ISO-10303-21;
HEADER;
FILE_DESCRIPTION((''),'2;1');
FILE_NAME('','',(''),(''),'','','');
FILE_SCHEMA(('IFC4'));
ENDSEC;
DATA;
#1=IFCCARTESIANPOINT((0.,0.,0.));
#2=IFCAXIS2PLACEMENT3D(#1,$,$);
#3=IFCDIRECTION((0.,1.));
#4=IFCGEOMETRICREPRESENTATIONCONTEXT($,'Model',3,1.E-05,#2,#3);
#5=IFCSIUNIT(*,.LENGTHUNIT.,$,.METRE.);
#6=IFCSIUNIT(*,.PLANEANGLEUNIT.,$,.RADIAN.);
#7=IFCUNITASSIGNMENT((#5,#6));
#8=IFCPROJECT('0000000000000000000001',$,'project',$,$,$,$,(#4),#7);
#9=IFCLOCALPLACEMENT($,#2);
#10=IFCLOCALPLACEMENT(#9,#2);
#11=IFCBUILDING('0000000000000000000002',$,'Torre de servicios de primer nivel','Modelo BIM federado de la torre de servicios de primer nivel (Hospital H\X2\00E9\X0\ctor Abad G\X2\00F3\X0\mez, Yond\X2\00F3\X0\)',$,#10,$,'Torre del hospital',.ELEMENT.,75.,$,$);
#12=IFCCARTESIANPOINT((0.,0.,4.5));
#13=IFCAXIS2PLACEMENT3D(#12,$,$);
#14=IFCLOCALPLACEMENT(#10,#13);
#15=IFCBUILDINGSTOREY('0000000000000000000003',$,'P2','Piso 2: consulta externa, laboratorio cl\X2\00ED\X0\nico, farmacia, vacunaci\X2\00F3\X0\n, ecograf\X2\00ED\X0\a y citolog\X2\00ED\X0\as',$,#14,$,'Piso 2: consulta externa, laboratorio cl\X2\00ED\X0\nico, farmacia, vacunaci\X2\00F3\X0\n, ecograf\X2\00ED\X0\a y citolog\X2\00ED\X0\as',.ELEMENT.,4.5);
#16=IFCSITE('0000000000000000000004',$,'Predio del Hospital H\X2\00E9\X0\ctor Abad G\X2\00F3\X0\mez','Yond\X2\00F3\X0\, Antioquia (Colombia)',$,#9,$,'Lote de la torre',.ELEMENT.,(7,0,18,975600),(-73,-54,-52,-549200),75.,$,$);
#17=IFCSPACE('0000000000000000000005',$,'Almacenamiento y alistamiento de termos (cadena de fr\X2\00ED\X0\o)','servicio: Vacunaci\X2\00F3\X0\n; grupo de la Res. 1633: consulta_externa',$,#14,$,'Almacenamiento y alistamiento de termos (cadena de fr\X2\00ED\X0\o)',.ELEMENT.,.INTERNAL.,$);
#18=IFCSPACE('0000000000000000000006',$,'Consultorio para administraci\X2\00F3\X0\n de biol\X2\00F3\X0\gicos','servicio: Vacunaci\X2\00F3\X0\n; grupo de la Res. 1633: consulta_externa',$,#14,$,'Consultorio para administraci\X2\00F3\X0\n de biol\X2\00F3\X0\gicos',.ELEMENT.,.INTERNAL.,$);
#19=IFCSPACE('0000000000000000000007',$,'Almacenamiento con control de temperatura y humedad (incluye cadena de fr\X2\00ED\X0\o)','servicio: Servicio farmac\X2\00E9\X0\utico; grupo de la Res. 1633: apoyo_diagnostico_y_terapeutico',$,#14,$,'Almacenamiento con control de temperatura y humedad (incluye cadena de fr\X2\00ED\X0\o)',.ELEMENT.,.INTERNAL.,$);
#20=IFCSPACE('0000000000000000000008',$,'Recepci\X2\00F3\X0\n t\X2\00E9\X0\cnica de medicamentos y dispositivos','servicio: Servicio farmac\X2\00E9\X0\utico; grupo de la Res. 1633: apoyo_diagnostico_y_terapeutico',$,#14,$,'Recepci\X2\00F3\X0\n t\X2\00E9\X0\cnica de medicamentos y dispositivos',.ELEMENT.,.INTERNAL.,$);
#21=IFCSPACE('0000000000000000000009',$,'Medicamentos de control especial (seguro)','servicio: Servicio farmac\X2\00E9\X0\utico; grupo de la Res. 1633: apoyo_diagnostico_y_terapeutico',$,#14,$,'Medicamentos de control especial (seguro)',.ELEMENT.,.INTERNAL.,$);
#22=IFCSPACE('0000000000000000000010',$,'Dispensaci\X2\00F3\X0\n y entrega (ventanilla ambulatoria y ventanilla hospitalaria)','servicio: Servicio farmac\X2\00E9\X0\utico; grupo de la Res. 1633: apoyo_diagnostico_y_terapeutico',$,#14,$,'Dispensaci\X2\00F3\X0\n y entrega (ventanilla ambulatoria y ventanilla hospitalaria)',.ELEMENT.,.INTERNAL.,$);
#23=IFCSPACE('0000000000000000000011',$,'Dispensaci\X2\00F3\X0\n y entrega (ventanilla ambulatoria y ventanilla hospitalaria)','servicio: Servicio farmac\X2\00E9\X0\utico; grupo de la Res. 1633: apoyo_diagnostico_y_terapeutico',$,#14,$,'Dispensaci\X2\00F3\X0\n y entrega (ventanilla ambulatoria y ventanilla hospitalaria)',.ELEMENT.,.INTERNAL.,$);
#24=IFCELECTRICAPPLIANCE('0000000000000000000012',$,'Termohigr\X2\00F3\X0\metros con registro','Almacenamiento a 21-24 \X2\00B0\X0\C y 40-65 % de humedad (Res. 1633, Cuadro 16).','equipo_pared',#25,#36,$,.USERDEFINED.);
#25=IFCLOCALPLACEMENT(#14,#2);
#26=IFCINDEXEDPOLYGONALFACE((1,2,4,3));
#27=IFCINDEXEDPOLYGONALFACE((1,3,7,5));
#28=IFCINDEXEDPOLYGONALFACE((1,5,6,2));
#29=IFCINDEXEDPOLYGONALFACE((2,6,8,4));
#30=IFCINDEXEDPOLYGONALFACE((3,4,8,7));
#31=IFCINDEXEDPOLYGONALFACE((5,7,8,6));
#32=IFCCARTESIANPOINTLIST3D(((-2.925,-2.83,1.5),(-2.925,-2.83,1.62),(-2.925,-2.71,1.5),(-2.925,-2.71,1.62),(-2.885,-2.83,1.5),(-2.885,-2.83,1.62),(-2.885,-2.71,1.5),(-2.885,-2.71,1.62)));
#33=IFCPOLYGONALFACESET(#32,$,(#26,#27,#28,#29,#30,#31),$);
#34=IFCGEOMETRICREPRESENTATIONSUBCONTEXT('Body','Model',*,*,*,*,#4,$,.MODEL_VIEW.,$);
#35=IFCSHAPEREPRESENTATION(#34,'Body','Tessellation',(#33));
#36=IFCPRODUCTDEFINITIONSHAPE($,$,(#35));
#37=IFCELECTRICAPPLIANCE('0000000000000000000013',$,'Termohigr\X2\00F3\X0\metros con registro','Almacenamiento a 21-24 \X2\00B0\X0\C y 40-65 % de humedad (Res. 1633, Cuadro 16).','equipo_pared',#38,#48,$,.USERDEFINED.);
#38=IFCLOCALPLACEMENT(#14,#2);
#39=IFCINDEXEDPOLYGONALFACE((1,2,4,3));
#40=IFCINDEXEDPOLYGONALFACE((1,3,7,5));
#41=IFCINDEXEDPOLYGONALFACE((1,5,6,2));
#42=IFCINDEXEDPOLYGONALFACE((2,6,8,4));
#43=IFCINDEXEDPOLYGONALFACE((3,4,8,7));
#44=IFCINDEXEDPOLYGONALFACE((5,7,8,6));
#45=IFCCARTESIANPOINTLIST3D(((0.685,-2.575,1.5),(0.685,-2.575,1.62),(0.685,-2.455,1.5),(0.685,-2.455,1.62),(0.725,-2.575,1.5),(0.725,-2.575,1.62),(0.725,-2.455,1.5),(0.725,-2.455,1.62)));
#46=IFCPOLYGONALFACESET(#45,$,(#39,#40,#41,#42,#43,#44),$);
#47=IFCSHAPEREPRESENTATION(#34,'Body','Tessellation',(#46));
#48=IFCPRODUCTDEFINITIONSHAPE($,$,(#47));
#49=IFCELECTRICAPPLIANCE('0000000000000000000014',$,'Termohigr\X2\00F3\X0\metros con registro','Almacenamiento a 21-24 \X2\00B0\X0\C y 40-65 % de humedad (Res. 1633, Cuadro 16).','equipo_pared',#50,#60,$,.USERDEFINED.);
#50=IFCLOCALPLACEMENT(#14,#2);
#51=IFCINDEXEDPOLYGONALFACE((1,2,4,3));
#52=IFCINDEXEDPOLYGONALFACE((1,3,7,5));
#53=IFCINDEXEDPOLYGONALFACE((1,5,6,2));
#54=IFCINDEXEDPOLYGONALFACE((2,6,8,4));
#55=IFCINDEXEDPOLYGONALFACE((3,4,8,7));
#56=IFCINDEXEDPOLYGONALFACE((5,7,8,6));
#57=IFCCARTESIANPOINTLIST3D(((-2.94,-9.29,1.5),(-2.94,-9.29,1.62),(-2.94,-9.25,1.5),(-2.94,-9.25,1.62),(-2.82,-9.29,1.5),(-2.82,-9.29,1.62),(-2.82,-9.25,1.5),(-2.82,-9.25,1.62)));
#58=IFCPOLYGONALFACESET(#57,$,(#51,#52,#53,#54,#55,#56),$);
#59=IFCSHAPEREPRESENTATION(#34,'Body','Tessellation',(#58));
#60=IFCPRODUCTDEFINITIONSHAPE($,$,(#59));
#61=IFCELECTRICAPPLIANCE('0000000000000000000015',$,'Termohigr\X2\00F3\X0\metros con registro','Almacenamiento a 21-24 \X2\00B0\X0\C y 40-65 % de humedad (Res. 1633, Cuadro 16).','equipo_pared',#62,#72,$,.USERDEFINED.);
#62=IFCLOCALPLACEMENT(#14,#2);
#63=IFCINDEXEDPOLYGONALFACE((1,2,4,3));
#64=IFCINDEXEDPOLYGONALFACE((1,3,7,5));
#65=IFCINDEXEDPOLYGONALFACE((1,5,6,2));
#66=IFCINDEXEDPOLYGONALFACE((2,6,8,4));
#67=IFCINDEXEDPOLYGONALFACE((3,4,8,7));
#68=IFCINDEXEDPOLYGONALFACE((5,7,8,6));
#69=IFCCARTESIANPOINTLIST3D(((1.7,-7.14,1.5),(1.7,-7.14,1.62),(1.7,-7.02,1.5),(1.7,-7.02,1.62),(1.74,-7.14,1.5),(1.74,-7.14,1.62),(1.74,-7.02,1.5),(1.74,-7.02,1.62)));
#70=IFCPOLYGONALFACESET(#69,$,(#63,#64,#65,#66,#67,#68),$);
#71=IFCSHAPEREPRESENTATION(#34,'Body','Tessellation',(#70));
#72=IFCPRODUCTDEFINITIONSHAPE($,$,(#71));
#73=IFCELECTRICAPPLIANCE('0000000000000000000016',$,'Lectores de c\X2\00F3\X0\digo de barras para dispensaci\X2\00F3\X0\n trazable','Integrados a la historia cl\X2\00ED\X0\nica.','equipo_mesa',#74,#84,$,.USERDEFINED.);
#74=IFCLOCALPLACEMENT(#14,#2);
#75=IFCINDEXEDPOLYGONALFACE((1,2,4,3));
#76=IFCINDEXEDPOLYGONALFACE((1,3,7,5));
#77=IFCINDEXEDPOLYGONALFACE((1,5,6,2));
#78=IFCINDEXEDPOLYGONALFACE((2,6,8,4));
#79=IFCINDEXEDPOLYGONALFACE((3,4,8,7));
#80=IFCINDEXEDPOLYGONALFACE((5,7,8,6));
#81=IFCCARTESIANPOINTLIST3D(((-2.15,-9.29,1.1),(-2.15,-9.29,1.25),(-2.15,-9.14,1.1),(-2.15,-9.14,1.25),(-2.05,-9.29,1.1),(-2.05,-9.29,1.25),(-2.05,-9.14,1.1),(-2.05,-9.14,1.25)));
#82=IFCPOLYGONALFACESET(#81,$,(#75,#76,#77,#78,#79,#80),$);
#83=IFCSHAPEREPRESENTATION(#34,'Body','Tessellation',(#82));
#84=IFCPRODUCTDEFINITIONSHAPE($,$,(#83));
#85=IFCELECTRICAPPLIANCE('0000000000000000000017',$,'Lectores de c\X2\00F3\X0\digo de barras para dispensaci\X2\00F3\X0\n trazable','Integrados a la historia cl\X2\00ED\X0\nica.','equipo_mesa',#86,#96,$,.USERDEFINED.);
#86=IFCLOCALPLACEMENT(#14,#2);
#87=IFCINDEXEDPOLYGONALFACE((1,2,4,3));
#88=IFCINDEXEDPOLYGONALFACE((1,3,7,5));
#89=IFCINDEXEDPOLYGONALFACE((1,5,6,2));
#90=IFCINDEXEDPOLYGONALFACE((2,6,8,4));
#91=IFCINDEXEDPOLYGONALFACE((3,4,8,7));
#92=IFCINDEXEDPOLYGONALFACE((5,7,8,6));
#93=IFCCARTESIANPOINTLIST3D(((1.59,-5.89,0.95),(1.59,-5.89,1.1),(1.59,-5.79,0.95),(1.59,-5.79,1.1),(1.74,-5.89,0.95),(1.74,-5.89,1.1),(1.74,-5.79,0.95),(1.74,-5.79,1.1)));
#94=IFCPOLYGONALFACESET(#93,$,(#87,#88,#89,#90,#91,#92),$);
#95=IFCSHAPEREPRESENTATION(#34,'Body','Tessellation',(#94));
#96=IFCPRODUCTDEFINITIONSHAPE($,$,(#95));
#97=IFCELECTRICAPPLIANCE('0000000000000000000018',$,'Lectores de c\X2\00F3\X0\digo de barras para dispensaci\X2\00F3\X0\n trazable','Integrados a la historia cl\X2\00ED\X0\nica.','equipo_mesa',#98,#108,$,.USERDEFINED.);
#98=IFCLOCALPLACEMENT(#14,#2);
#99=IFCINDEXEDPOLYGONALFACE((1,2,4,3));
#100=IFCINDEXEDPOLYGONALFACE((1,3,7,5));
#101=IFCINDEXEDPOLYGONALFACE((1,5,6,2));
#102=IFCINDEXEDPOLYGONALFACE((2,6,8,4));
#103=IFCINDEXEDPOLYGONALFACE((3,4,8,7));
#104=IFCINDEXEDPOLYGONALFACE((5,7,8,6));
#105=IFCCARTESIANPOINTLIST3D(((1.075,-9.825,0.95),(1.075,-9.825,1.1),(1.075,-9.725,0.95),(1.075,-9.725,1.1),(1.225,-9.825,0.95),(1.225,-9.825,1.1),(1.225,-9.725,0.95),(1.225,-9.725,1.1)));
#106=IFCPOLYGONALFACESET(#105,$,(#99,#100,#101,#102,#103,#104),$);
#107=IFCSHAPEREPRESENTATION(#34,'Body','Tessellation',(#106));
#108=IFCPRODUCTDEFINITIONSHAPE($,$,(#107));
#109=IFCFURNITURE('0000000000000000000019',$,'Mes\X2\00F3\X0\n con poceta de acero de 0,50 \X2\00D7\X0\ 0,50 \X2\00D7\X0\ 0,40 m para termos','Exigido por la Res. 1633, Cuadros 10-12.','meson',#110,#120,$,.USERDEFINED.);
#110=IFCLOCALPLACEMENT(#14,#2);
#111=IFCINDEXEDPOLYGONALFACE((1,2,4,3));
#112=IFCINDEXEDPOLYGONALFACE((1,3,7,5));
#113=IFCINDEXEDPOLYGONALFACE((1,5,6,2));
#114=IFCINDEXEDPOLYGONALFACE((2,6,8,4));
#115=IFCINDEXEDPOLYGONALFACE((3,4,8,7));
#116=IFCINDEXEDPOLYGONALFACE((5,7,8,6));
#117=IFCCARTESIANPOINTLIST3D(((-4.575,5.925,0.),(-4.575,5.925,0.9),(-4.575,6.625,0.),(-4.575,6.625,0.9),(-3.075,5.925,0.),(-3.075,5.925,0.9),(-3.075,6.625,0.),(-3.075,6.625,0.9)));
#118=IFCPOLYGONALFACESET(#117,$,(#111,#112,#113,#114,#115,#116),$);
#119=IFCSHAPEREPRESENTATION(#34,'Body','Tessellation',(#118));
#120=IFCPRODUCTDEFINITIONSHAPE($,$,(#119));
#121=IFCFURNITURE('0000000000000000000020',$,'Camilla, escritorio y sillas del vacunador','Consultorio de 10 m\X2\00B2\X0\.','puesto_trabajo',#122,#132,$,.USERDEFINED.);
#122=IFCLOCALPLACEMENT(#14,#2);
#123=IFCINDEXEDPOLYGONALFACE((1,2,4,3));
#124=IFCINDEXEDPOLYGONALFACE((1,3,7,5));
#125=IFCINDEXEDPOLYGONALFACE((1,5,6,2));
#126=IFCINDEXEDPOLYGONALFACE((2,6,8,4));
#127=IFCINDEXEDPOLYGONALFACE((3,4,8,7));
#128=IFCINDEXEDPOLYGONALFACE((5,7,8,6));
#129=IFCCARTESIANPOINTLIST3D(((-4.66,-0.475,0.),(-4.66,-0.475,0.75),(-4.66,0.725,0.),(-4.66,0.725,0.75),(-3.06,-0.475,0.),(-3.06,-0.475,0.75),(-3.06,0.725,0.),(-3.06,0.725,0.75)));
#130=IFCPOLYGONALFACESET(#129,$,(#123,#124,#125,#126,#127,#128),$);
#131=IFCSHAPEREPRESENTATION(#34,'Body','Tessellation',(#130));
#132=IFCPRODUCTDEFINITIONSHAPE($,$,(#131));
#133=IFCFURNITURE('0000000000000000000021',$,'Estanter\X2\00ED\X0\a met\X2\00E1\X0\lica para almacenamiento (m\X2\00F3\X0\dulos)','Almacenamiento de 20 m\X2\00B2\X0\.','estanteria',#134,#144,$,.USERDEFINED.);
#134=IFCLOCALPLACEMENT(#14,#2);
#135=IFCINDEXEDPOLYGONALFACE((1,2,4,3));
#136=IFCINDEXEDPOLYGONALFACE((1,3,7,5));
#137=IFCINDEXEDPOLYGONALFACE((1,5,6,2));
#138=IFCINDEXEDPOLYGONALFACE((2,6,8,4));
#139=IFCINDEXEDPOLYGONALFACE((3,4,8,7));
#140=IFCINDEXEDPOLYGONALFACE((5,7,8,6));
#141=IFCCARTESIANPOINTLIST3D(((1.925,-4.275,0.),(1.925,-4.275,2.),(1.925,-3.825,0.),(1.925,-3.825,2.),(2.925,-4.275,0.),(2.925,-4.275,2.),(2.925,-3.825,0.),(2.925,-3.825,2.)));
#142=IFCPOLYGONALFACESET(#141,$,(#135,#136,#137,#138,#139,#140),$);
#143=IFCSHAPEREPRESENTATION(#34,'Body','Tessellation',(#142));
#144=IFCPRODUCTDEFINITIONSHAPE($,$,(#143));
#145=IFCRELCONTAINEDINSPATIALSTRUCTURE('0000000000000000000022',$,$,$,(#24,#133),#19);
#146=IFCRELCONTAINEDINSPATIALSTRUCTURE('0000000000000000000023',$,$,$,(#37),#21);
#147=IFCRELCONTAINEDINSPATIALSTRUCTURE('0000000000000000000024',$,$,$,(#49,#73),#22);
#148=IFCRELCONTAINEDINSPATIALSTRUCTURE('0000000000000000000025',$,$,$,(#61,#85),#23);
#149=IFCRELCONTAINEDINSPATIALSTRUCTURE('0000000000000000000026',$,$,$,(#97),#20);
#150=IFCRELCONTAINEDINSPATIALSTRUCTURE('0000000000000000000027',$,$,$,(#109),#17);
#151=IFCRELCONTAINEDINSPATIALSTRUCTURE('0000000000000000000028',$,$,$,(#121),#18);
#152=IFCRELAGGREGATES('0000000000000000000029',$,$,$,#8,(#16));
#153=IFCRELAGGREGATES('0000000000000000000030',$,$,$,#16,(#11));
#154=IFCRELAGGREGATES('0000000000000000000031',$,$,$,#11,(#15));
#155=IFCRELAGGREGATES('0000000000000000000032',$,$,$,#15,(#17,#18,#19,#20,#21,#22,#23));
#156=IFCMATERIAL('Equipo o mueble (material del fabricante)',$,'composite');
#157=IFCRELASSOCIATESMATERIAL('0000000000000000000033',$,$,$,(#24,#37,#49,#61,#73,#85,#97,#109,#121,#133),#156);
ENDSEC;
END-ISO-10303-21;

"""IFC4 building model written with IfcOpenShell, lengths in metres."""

from ifc_helpers import new_model, si_unit, direction, frame, origin, place, context, subcontext, project, spatial, rectangle, extrude, material, element, save


model = new_model("IFC4")

# Units and contexts
model_context = context("Model", 3, precision=1e-05, world=origin(), true_north=direction((0.0, 1.0)))
body_context = subcontext(model_context, "Body", "Model", "MODEL_VIEW")
ifc_project = project(units=[si_unit("LENGTHUNIT", "METRE"), si_unit("PLANEANGLEUNIT", "RADIAN")], contexts=[model_context])

# Site, building, storey, space
site_placement = place(None, origin())
site = spatial("IfcSite", under=ifc_project, at=site_placement, Name="Predio del Hospital Héctor Abad Gómez", Description="Yondó, Antioquia (Colombia)", LongName="Lote de la torre", CompositionType="ELEMENT", RefLatitude=(7, 0, 18, 975600), RefLongitude=(-73, -54, -52, -549200), RefElevation=75.0)
building_placement = place(site_placement, origin())
building = spatial("IfcBuilding", under=site, at=building_placement, Name="Torre de servicios de primer nivel", Description="Modelo BIM federado de la torre de servicios de primer nivel (Hospital Héctor Abad Gómez, Yondó)", LongName="Torre del hospital", CompositionType="ELEMENT", ElevationOfRefHeight=75.0)
placement = place(building_placement, frame((0.0, 0.0, 4.5)))
storey = spatial("IfcBuildingStorey", under=building, at=placement, Name="P2", Description="Piso 2: consulta externa, laboratorio clínico, farmacia, vacunación, ecografía y citologías", LongName="Piso 2: consulta externa, laboratorio clínico, farmacia, vacunación, ecografía y citologías", CompositionType="ELEMENT", Elevation=4.5)
space_1 = spatial("IfcSpace", under=storey, at=placement, Name="Almacenamiento y alistamiento de termos (cadena de frío)", Description="servicio: Vacunación; grupo de la Res. 1633: consulta_externa", LongName="Almacenamiento y alistamiento de termos (cadena de frío)", CompositionType="ELEMENT", PredefinedType="INTERNAL")

# Shared definitions
ifc_material = material(Name="Equipo o mueble (material del fabricante)", Category="composite")

# Shared definitions
space_2 = spatial("IfcSpace", under=storey, at=placement, Name="Consultorio para administración de biológicos", Description="servicio: Vacunación; grupo de la Res. 1633: consulta_externa", LongName="Consultorio para administración de biológicos", CompositionType="ELEMENT", PredefinedType="INTERNAL")

# Shared definitions
space_3 = spatial("IfcSpace", under=storey, at=placement, Name="Almacenamiento con control de temperatura y humedad (incluye cadena de frío)", Description="servicio: Servicio farmacéutico; grupo de la Res. 1633: apoyo_diagnostico_y_terapeutico", LongName="Almacenamiento con control de temperatura y humedad (incluye cadena de frío)", CompositionType="ELEMENT", PredefinedType="INTERNAL")

# Shared definitions
space_4 = spatial("IfcSpace", under=storey, at=placement, Name="Recepción técnica de medicamentos y dispositivos", Description="servicio: Servicio farmacéutico; grupo de la Res. 1633: apoyo_diagnostico_y_terapeutico", LongName="Recepción técnica de medicamentos y dispositivos", CompositionType="ELEMENT", PredefinedType="INTERNAL")

# Electric appliance
element("IfcElectricAppliance", 1, at=placement, inside=space_3, material=ifc_material, Name="Termohigrómetros con registro", Description="Almacenamiento a 21-24 °C y 40-65 % de humedad (Res. 1633, Cuadro 16).", ObjectType="equipo_pared", PredefinedType="USERDEFINED", context=body_context, shape_type="SweptSolid", body=[
    extrude(rectangle(XDim=0.12, YDim=0.04), frame((-2.905, -2.77, 1.5), z_axis=(0.0, 0.0, 1.0), x_axis=(0.0, -1.0, 0.0)), (0.0, 0.0, 1.0), 0.12),
])

# Shared definitions
space_5 = spatial("IfcSpace", under=storey, at=placement, Name="Medicamentos de control especial (seguro)", Description="servicio: Servicio farmacéutico; grupo de la Res. 1633: apoyo_diagnostico_y_terapeutico", LongName="Medicamentos de control especial (seguro)", CompositionType="ELEMENT", PredefinedType="INTERNAL")

# Electric appliance
element("IfcElectricAppliance", 2, at=placement, inside=space_5, material=ifc_material, Name="Termohigrómetros con registro", Description="Almacenamiento a 21-24 °C y 40-65 % de humedad (Res. 1633, Cuadro 16).", ObjectType="equipo_pared", PredefinedType="USERDEFINED", context=body_context, shape_type="SweptSolid", body=[
    extrude(rectangle(XDim=0.12, YDim=0.04), frame((0.705, -2.515, 1.5), z_axis=(0.0, 0.0, 1.0), x_axis=(0.0, 1.0, 0.0)), (0.0, 0.0, 1.0), 0.12),
])

# Shared definitions
space_6 = spatial("IfcSpace", under=storey, at=placement, Name="Dispensación y entrega (ventanilla ambulatoria y ventanilla hospitalaria)", Description="servicio: Servicio farmacéutico; grupo de la Res. 1633: apoyo_diagnostico_y_terapeutico", LongName="Dispensación y entrega (ventanilla ambulatoria y ventanilla hospitalaria)", CompositionType="ELEMENT", PredefinedType="INTERNAL")

# Electric appliance
element("IfcElectricAppliance", 3, at=placement, inside=space_6, material=ifc_material, Name="Termohigrómetros con registro", Description="Almacenamiento a 21-24 °C y 40-65 % de humedad (Res. 1633, Cuadro 16).", ObjectType="equipo_pared", PredefinedType="USERDEFINED", context=body_context, shape_type="SweptSolid", body=[
    extrude(rectangle(XDim=0.12, YDim=0.04), frame((-2.88, -9.27, 1.5)), (0.0, 0.0, 1.0), 0.12),
])

# Shared definitions
space_7 = spatial("IfcSpace", under=storey, at=placement, Name="Dispensación y entrega (ventanilla ambulatoria y ventanilla hospitalaria)", Description="servicio: Servicio farmacéutico; grupo de la Res. 1633: apoyo_diagnostico_y_terapeutico", LongName="Dispensación y entrega (ventanilla ambulatoria y ventanilla hospitalaria)", CompositionType="ELEMENT", PredefinedType="INTERNAL")

# Electric appliances
element("IfcElectricAppliance", 4, at=placement, inside=space_7, material=ifc_material, Name="Termohigrómetros con registro", Description="Almacenamiento a 21-24 °C y 40-65 % de humedad (Res. 1633, Cuadro 16).", ObjectType="equipo_pared", PredefinedType="USERDEFINED", context=body_context, shape_type="SweptSolid", body=[
    extrude(rectangle(XDim=0.12, YDim=0.04), frame((1.72, -7.08, 1.5), z_axis=(0.0, 0.0, 1.0), x_axis=(0.0, 1.0, 0.0)), (0.0, 0.0, 1.0), 0.12),
])
element("IfcElectricAppliance", 5, at=placement, inside=space_6, material=ifc_material, Name="Lectores de código de barras para dispensación trazable", Description="Integrados a la historia clínica.", ObjectType="equipo_mesa", PredefinedType="USERDEFINED", context=body_context, shape_type="SweptSolid", body=[
    extrude(rectangle(XDim=0.1, YDim=0.15), frame((-2.1, -9.215, 1.1)), (0.0, 0.0, 1.0), 0.15),
])
element("IfcElectricAppliance", 6, at=placement, inside=space_7, material=ifc_material, Name="Lectores de código de barras para dispensación trazable", Description="Integrados a la historia clínica.", ObjectType="equipo_mesa", PredefinedType="USERDEFINED", context=body_context, shape_type="SweptSolid", body=[
    extrude(rectangle(XDim=0.1, YDim=0.15), frame((1.665, -5.84, 0.95), z_axis=(0.0, 0.0, 1.0), x_axis=(0.0, 1.0, 0.0)), (0.0, 0.0, 1.0), 0.15),
])
element("IfcElectricAppliance", 7, at=placement, inside=space_4, material=ifc_material, Name="Lectores de código de barras para dispensación trazable", Description="Integrados a la historia clínica.", ObjectType="equipo_mesa", PredefinedType="USERDEFINED", context=body_context, shape_type="SweptSolid", body=[
    extrude(rectangle(XDim=0.1, YDim=0.15), frame((1.15, -9.775, 0.95), z_axis=(0.0, 0.0, 1.0), x_axis=(0.0, 1.0, 0.0)), (0.0, 0.0, 1.0), 0.15),
])

# Furniture
element("IfcFurniture", 8, at=placement, inside=space_1, material=ifc_material, Name="Mesón con poceta de acero de 0,50 × 0,50 × 0,40 m para termos", Description="Exigido por la Res. 1633, Cuadros 10-12.", ObjectType="meson", PredefinedType="USERDEFINED", context=body_context, shape_type="SweptSolid", body=[
    extrude(rectangle(XDim=1.5, YDim=0.7), frame((-3.825, 6.275, 0.0), z_axis=(0.0, 0.0, 1.0), x_axis=(-1.0, 0.0, 0.0)), (0.0, 0.0, 1.0), 0.9),
])
element("IfcFurniture", 9, at=placement, inside=space_2, material=ifc_material, Name="Camilla, escritorio y sillas del vacunador", Description="Consultorio de 10 m².", ObjectType="puesto_trabajo", PredefinedType="USERDEFINED", context=body_context, shape_type="SweptSolid", body=[
    extrude(rectangle(XDim=1.2, YDim=1.6), frame((-3.86, 0.125, 0.0), z_axis=(0.0, 0.0, 1.0), x_axis=(0.0, 1.0, 0.0)), (0.0, 0.0, 1.0), 0.75),
])
element("IfcFurniture", 10, at=placement, inside=space_3, material=ifc_material, Name="Estantería metálica para almacenamiento (módulos)", Description="Almacenamiento de 20 m².", ObjectType="estanteria", PredefinedType="USERDEFINED", context=body_context, shape_type="SweptSolid", body=[
    extrude(rectangle(XDim=1.0, YDim=0.45), frame((2.425, -4.05, 0.0)), (0.0, 0.0, 1.0), 2.0),
])

save(model, "model.ifc")
